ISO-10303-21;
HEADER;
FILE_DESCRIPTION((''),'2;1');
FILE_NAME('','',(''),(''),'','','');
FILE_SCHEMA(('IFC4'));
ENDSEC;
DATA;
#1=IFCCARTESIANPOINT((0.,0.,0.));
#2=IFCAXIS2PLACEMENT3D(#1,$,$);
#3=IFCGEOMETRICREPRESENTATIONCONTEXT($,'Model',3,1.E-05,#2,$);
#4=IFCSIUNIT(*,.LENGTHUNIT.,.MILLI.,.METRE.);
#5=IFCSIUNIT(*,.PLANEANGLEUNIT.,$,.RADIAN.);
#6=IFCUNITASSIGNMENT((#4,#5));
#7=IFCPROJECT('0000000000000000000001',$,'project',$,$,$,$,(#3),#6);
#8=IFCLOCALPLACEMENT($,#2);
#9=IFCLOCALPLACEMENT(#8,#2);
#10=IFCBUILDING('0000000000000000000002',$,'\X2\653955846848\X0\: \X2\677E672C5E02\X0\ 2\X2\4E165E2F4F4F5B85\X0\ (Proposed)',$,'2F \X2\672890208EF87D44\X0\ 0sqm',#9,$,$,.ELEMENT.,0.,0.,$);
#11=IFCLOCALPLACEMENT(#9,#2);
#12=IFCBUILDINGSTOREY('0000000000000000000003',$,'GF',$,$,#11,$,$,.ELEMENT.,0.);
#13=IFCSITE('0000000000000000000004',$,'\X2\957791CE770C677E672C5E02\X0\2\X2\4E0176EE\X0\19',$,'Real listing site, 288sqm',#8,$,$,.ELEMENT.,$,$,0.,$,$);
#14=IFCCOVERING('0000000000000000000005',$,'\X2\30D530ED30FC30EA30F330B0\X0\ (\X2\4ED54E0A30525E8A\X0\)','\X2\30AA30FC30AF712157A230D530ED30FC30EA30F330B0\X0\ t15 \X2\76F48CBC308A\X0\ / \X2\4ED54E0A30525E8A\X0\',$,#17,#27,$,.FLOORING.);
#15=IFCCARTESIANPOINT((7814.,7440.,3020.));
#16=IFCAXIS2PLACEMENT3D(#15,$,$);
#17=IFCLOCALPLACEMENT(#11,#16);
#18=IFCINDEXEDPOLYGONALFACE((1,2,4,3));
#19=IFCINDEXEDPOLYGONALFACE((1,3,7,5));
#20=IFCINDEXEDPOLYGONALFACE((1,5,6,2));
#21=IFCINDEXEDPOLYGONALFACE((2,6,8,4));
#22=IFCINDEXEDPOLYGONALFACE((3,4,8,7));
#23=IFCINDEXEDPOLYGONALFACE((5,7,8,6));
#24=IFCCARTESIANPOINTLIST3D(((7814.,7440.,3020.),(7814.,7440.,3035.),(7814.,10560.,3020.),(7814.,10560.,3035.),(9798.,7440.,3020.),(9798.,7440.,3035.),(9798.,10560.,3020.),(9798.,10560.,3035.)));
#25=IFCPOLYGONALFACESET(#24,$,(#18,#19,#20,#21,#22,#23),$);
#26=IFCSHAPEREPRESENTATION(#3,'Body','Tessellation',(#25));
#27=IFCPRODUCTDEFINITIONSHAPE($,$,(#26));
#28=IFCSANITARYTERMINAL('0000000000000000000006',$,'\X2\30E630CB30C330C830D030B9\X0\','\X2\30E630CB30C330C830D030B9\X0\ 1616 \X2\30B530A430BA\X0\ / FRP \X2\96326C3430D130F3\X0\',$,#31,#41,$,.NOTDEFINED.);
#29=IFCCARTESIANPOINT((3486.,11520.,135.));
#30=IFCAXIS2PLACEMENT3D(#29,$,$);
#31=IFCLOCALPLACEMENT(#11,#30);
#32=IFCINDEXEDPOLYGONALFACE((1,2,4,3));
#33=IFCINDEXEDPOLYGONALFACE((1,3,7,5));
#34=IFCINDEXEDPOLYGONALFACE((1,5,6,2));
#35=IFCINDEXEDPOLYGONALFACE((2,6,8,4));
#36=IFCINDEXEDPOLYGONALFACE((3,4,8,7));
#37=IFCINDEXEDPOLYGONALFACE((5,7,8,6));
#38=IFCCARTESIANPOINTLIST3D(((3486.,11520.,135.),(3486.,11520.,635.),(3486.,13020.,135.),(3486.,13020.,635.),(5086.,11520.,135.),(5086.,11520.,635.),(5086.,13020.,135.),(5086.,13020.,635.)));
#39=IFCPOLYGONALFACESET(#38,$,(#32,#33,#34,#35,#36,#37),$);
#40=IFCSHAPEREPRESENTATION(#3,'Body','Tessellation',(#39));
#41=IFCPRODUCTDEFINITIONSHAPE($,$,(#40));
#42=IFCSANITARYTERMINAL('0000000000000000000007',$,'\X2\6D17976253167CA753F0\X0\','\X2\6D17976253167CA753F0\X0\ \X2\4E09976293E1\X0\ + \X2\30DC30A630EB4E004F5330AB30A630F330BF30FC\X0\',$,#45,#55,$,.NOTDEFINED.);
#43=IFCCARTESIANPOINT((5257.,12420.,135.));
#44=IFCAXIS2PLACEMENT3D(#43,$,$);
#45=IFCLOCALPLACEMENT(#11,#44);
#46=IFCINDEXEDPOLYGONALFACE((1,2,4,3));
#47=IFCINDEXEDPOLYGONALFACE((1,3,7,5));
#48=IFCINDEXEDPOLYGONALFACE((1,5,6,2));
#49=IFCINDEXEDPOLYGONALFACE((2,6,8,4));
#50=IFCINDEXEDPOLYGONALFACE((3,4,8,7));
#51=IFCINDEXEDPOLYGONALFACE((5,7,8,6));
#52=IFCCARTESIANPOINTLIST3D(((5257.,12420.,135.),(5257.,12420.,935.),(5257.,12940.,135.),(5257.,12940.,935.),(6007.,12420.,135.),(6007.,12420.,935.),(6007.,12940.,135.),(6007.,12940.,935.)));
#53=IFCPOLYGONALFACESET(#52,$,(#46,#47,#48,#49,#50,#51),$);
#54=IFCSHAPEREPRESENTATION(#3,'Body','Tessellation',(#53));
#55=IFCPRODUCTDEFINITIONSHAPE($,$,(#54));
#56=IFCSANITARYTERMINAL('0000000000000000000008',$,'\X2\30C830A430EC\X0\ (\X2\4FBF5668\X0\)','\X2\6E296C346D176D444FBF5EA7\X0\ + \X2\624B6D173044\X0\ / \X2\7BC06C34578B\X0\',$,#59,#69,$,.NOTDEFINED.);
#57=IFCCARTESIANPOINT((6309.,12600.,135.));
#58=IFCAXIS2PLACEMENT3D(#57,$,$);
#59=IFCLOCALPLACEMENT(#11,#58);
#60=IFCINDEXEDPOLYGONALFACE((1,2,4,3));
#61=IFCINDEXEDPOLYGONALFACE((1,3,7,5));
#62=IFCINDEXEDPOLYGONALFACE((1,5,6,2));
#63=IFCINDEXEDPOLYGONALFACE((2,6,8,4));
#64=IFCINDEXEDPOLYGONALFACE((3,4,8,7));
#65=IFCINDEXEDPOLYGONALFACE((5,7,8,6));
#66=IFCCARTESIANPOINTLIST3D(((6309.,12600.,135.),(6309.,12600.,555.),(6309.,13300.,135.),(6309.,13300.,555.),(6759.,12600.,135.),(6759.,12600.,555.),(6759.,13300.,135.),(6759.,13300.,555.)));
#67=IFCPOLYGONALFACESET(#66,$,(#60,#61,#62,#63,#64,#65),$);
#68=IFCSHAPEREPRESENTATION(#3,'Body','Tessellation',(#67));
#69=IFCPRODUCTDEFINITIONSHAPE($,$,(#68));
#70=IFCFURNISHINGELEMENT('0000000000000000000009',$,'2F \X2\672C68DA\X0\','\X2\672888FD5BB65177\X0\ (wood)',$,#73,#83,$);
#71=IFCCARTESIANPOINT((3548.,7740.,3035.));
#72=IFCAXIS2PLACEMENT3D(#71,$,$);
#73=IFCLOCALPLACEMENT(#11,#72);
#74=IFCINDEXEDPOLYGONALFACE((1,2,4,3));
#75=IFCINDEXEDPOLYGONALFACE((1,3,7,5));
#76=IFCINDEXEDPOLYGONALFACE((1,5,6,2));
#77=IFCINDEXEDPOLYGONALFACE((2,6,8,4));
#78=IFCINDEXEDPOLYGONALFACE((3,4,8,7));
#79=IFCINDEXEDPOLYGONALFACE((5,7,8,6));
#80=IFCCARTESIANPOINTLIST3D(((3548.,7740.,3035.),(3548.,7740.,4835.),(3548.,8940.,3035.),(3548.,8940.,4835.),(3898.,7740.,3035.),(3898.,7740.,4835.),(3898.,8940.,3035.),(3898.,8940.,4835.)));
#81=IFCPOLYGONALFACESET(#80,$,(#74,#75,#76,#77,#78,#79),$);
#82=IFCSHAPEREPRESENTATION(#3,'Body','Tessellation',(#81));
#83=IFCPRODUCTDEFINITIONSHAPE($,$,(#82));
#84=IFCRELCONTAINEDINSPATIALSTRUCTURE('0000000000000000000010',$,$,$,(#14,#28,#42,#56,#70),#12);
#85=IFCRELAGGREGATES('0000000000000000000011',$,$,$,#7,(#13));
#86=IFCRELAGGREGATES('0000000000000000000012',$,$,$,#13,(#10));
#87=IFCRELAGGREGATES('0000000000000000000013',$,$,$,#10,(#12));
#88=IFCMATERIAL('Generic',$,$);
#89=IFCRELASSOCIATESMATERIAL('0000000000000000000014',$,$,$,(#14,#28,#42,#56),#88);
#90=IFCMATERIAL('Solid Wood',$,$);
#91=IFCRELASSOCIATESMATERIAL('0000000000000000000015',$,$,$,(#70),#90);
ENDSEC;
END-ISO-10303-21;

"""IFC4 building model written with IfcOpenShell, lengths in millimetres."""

from ifc_helpers import new_model, si_unit, frame, frame_2d, origin, place, context, project, spatial, rectangle, extrude, material, element, save


model = new_model("IFC4")

# Units and contexts
model_context = context("Model", 3, precision=1e-05, world=origin())
ifc_project = project(units=[si_unit("LENGTHUNIT", "METRE", prefix="MILLI"), si_unit("PLANEANGLEUNIT", "RADIAN")], contexts=[model_context])

# Site, building, storey
site_placement = place(None, origin())
site = spatial("IfcSite", under=ifc_project, at=site_placement, Name="長野県松本市2丁目19", ObjectType="Real listing site, 288sqm", CompositionType="ELEMENT", RefElevation=0.0)
building_placement = place(site_placement, origin())
building = spatial("IfcBuilding", under=site, at=building_placement, Name="改善案: 松本市 2世帯住宅 (Proposed)", ObjectType="2F 木造軸組 0sqm", CompositionType="ELEMENT", ElevationOfRefHeight=0.0, ElevationOfTerrain=0.0)
storey_placement = place(building_placement, origin())
storey = spatial("IfcBuildingStorey", under=building, at=storey_placement, Name="GF", CompositionType="ELEMENT", Elevation=0.0)

# Shared definitions
ifc_material_1 = material(Name="Solid Wood")

# Shared definitions
ifc_material_2 = material(Name="Generic")

# Covering
covering_1_placement = place(storey_placement, frame((7814.0, 7440.0, 3020.0)))
element("IfcCovering", 1, at=covering_1_placement, inside=storey, material=ifc_material_2, Name="フローリング (仕上げ床)", Description="オーク無垢フローリング t15 直貼り / 仕上げ床", PredefinedType="FLOORING", context=model_context, shape_type="SweptSolid", body=[
    extrude(rectangle(XDim=1984.0, YDim=3120.0, at=frame_2d((992.0, 1560.0))), frame((7814.0, 7440.0, 3020.0)), (0.0, 0.0, 1.0), 15.0),
])

# Sanitary terminals
sanitary_terminal_1_placement = place(storey_placement, frame((3486.0, 11520.0, 135.0)))
element("IfcSanitaryTerminal", 2, at=sanitary_terminal_1_placement, inside=storey, material=ifc_material_2, Name="ユニットバス", Description="ユニットバス 1616 サイズ / FRP 防水パン", PredefinedType="NOTDEFINED", context=model_context, shape_type="SweptSolid", body=[
    extrude(rectangle(XDim=1600.0, YDim=1500.0, at=frame_2d((800.0, 750.0))), frame((3486.0, 11520.0, 135.0)), (0.0, 0.0, 1.0), 500.0),
])
sanitary_terminal_2_placement = place(storey_placement, frame((5257.0, 12420.0, 135.0)))
element("IfcSanitaryTerminal", 3, at=sanitary_terminal_2_placement, inside=storey, material=ifc_material_2, Name="洗面化粧台", Description="洗面化粧台 三面鏡 + ボウル一体カウンター", PredefinedType="NOTDEFINED", context=model_context, shape_type="SweptSolid", body=[
    extrude(rectangle(XDim=750.0, YDim=520.0, at=frame_2d((375.0, 260.0))), frame((5257.0, 12420.0, 135.0)), (0.0, 0.0, 1.0), 800.0),
])
sanitary_terminal_3_placement = place(storey_placement, frame((6309.0, 12600.0, 135.0)))
element("IfcSanitaryTerminal", 4, at=sanitary_terminal_3_placement, inside=storey, material=ifc_material_2, Name="トイレ (便器)", Description="温水洗浄便座 + 手洗い / 節水型", PredefinedType="NOTDEFINED", context=model_context, shape_type="SweptSolid", body=[
    extrude(rectangle(XDim=450.0, YDim=700.0, at=frame_2d((225.0, 350.0))), frame((6309.0, 12600.0, 135.0)), (0.0, 0.0, 1.0), 420.0),
])

# Furnishing element
furnishing_placement = place(storey_placement, frame((3548.0, 7740.0, 3035.0)))
element("IfcFurnishingElement", 5, at=furnishing_placement, inside=storey, material=ifc_material_1, Name="2F 本棚", Description="木製家具 (wood)", context=model_context, shape_type="SweptSolid", body=[
    extrude(rectangle(XDim=350.0, YDim=1200.0, at=frame_2d((175.0, 600.0))), frame((3548.0, 7740.0, 3035.0)), (0.0, 0.0, 1.0), 1800.0),
])

save(model, "model.ifc")
